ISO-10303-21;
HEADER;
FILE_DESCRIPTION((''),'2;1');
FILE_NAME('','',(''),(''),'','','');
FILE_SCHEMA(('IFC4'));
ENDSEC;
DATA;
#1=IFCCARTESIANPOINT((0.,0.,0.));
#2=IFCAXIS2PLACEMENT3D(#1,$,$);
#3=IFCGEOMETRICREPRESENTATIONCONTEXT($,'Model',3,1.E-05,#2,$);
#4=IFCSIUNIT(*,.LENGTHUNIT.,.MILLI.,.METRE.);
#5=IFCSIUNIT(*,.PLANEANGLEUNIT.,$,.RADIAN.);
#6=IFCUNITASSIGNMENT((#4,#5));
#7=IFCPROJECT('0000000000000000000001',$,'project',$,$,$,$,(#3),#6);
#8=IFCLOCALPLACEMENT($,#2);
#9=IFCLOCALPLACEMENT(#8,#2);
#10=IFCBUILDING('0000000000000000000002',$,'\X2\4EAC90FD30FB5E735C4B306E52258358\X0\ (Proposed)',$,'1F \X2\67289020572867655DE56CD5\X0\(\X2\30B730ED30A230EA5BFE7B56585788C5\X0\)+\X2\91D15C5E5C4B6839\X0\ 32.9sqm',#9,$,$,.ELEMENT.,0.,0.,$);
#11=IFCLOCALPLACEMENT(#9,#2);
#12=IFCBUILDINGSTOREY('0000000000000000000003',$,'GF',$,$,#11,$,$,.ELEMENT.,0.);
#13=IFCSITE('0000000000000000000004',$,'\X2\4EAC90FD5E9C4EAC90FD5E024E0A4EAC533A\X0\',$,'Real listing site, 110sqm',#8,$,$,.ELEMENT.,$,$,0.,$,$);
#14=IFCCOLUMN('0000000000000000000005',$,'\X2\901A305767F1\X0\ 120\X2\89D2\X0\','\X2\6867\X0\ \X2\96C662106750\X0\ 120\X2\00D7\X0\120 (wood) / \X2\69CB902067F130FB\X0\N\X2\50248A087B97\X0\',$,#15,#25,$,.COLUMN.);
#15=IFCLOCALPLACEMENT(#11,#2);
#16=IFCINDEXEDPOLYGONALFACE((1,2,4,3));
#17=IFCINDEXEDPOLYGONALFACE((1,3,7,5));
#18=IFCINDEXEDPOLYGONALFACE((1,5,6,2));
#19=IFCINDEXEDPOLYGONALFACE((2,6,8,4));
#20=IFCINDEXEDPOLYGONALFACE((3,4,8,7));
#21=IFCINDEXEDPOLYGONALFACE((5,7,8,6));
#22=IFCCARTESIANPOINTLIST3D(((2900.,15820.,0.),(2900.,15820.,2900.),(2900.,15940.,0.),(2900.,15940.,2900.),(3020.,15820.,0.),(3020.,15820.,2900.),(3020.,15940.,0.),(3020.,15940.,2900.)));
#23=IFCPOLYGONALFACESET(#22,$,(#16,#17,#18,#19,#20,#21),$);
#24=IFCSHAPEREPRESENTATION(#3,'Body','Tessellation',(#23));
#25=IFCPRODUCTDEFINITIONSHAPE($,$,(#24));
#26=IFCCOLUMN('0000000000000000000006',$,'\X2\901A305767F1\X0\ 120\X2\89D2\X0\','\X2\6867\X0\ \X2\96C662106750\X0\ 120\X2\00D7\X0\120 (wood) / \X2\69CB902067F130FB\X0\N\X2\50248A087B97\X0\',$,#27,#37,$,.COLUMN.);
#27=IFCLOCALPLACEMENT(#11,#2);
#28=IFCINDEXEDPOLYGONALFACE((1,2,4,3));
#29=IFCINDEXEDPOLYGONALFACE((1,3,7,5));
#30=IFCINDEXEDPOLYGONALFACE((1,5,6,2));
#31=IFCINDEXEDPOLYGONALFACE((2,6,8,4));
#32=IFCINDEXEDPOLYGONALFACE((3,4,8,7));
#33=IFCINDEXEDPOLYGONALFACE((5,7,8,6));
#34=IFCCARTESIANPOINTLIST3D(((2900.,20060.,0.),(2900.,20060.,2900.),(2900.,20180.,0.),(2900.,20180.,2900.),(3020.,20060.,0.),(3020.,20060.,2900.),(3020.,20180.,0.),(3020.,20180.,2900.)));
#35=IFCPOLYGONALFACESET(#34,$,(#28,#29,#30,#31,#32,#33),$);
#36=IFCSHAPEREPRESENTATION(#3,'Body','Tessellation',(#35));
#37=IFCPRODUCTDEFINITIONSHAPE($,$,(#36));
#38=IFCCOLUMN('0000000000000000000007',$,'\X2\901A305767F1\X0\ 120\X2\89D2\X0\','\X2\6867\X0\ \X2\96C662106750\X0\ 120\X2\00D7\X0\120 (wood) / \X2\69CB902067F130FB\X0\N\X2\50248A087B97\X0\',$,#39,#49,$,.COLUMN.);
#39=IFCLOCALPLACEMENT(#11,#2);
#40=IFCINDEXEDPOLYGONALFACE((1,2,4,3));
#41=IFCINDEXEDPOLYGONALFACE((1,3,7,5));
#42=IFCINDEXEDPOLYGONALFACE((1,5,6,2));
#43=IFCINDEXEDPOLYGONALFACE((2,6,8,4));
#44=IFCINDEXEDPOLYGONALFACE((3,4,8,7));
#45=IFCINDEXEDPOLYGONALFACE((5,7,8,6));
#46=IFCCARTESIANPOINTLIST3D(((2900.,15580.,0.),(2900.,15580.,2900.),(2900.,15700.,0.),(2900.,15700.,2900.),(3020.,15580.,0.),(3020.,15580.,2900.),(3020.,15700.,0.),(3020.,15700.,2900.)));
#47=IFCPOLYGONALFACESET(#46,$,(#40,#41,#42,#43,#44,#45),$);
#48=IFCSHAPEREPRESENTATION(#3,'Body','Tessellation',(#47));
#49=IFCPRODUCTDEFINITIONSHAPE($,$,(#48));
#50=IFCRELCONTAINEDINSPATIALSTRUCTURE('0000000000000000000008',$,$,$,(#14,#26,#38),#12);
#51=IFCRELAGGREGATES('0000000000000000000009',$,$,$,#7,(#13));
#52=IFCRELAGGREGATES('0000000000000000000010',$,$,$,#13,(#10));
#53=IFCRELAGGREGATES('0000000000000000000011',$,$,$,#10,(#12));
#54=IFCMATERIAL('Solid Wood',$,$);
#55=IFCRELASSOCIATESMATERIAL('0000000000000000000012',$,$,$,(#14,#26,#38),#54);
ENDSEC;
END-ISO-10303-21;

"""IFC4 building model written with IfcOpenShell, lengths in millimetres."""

from ifc_helpers import new_model, si_unit, frame, frame_2d, origin, place, context, project, spatial, rectangle, extrude, material, element, save


model = new_model("IFC4")

# Units and contexts
model_context = context("Model", 3, precision=1e-05, world=origin())
ifc_project = project(units=[si_unit("LENGTHUNIT", "METRE", prefix="MILLI"), si_unit("PLANEANGLEUNIT", "RADIAN")], contexts=[model_context])

# Site, building, storey
site_placement = place(None, origin())
site = spatial("IfcSite", under=ifc_project, at=site_placement, Name="京都府京都市上京区", ObjectType="Real listing site, 110sqm", CompositionType="ELEMENT", RefElevation=0.0)
building_placement = place(site_placement, origin())
building = spatial("IfcBuilding", under=site, at=building_placement, Name="京都・平屋の別荘 (Proposed)", ObjectType="1F 木造在来工法(シロアリ対策塗装)+金属屋根 32.9sqm", CompositionType="ELEMENT", ElevationOfRefHeight=0.0, ElevationOfTerrain=0.0)
storey_placement = place(building_placement, origin())
storey = spatial("IfcBuildingStorey", under=building, at=storey_placement, Name="GF", CompositionType="ELEMENT", Elevation=0.0)

# Columns
ifc_material_1 = material(Name="Solid Wood")
column_1_placement = place(storey_placement, frame((1450.0, 7910.0, 0.0)))
element("IfcColumn", 1, at=column_1_placement, inside=storey, material=ifc_material_1, Name="通し柱 120角", Description="桧 集成材 120×120 (wood) / 構造柱・N値計算", PredefinedType="COLUMN", context=model_context, shape_type="SweptSolid", body=[
    extrude(rectangle(XDim=120.0, YDim=120.0, at=frame_2d((60.0, 60.0))), frame((1450.0, 7910.0, 0.0)), (0.0, 0.0, 1.0), 2900.0),
])
column_2_placement = place(storey_placement, frame((1450.0, 10030.0, 0.0)))
element("IfcColumn", 2, at=column_2_placement, inside=storey, material=ifc_material_1, Name="通し柱 120角", Description="桧 集成材 120×120 (wood) / 構造柱・N値計算", PredefinedType="COLUMN", context=model_context, shape_type="SweptSolid", body=[
    extrude(rectangle(XDim=120.0, YDim=120.0, at=frame_2d((60.0, 60.0))), frame((1450.0, 10030.0, 0.0)), (0.0, 0.0, 1.0), 2900.0),
])
column_3_placement = place(storey_placement, frame((1450.0, 7790.0, 0.0)))
element("IfcColumn", 3, at=column_3_placement, inside=storey, material=ifc_material_1, Name="通し柱 120角", Description="桧 集成材 120×120 (wood) / 構造柱・N値計算", PredefinedType="COLUMN", context=model_context, shape_type="SweptSolid", body=[
    extrude(rectangle(XDim=120.0, YDim=120.0, at=frame_2d((60.0, 60.0))), frame((1450.0, 7790.0, 0.0)), (0.0, 0.0, 1.0), 2900.0),
])

save(model, "model.ifc")
